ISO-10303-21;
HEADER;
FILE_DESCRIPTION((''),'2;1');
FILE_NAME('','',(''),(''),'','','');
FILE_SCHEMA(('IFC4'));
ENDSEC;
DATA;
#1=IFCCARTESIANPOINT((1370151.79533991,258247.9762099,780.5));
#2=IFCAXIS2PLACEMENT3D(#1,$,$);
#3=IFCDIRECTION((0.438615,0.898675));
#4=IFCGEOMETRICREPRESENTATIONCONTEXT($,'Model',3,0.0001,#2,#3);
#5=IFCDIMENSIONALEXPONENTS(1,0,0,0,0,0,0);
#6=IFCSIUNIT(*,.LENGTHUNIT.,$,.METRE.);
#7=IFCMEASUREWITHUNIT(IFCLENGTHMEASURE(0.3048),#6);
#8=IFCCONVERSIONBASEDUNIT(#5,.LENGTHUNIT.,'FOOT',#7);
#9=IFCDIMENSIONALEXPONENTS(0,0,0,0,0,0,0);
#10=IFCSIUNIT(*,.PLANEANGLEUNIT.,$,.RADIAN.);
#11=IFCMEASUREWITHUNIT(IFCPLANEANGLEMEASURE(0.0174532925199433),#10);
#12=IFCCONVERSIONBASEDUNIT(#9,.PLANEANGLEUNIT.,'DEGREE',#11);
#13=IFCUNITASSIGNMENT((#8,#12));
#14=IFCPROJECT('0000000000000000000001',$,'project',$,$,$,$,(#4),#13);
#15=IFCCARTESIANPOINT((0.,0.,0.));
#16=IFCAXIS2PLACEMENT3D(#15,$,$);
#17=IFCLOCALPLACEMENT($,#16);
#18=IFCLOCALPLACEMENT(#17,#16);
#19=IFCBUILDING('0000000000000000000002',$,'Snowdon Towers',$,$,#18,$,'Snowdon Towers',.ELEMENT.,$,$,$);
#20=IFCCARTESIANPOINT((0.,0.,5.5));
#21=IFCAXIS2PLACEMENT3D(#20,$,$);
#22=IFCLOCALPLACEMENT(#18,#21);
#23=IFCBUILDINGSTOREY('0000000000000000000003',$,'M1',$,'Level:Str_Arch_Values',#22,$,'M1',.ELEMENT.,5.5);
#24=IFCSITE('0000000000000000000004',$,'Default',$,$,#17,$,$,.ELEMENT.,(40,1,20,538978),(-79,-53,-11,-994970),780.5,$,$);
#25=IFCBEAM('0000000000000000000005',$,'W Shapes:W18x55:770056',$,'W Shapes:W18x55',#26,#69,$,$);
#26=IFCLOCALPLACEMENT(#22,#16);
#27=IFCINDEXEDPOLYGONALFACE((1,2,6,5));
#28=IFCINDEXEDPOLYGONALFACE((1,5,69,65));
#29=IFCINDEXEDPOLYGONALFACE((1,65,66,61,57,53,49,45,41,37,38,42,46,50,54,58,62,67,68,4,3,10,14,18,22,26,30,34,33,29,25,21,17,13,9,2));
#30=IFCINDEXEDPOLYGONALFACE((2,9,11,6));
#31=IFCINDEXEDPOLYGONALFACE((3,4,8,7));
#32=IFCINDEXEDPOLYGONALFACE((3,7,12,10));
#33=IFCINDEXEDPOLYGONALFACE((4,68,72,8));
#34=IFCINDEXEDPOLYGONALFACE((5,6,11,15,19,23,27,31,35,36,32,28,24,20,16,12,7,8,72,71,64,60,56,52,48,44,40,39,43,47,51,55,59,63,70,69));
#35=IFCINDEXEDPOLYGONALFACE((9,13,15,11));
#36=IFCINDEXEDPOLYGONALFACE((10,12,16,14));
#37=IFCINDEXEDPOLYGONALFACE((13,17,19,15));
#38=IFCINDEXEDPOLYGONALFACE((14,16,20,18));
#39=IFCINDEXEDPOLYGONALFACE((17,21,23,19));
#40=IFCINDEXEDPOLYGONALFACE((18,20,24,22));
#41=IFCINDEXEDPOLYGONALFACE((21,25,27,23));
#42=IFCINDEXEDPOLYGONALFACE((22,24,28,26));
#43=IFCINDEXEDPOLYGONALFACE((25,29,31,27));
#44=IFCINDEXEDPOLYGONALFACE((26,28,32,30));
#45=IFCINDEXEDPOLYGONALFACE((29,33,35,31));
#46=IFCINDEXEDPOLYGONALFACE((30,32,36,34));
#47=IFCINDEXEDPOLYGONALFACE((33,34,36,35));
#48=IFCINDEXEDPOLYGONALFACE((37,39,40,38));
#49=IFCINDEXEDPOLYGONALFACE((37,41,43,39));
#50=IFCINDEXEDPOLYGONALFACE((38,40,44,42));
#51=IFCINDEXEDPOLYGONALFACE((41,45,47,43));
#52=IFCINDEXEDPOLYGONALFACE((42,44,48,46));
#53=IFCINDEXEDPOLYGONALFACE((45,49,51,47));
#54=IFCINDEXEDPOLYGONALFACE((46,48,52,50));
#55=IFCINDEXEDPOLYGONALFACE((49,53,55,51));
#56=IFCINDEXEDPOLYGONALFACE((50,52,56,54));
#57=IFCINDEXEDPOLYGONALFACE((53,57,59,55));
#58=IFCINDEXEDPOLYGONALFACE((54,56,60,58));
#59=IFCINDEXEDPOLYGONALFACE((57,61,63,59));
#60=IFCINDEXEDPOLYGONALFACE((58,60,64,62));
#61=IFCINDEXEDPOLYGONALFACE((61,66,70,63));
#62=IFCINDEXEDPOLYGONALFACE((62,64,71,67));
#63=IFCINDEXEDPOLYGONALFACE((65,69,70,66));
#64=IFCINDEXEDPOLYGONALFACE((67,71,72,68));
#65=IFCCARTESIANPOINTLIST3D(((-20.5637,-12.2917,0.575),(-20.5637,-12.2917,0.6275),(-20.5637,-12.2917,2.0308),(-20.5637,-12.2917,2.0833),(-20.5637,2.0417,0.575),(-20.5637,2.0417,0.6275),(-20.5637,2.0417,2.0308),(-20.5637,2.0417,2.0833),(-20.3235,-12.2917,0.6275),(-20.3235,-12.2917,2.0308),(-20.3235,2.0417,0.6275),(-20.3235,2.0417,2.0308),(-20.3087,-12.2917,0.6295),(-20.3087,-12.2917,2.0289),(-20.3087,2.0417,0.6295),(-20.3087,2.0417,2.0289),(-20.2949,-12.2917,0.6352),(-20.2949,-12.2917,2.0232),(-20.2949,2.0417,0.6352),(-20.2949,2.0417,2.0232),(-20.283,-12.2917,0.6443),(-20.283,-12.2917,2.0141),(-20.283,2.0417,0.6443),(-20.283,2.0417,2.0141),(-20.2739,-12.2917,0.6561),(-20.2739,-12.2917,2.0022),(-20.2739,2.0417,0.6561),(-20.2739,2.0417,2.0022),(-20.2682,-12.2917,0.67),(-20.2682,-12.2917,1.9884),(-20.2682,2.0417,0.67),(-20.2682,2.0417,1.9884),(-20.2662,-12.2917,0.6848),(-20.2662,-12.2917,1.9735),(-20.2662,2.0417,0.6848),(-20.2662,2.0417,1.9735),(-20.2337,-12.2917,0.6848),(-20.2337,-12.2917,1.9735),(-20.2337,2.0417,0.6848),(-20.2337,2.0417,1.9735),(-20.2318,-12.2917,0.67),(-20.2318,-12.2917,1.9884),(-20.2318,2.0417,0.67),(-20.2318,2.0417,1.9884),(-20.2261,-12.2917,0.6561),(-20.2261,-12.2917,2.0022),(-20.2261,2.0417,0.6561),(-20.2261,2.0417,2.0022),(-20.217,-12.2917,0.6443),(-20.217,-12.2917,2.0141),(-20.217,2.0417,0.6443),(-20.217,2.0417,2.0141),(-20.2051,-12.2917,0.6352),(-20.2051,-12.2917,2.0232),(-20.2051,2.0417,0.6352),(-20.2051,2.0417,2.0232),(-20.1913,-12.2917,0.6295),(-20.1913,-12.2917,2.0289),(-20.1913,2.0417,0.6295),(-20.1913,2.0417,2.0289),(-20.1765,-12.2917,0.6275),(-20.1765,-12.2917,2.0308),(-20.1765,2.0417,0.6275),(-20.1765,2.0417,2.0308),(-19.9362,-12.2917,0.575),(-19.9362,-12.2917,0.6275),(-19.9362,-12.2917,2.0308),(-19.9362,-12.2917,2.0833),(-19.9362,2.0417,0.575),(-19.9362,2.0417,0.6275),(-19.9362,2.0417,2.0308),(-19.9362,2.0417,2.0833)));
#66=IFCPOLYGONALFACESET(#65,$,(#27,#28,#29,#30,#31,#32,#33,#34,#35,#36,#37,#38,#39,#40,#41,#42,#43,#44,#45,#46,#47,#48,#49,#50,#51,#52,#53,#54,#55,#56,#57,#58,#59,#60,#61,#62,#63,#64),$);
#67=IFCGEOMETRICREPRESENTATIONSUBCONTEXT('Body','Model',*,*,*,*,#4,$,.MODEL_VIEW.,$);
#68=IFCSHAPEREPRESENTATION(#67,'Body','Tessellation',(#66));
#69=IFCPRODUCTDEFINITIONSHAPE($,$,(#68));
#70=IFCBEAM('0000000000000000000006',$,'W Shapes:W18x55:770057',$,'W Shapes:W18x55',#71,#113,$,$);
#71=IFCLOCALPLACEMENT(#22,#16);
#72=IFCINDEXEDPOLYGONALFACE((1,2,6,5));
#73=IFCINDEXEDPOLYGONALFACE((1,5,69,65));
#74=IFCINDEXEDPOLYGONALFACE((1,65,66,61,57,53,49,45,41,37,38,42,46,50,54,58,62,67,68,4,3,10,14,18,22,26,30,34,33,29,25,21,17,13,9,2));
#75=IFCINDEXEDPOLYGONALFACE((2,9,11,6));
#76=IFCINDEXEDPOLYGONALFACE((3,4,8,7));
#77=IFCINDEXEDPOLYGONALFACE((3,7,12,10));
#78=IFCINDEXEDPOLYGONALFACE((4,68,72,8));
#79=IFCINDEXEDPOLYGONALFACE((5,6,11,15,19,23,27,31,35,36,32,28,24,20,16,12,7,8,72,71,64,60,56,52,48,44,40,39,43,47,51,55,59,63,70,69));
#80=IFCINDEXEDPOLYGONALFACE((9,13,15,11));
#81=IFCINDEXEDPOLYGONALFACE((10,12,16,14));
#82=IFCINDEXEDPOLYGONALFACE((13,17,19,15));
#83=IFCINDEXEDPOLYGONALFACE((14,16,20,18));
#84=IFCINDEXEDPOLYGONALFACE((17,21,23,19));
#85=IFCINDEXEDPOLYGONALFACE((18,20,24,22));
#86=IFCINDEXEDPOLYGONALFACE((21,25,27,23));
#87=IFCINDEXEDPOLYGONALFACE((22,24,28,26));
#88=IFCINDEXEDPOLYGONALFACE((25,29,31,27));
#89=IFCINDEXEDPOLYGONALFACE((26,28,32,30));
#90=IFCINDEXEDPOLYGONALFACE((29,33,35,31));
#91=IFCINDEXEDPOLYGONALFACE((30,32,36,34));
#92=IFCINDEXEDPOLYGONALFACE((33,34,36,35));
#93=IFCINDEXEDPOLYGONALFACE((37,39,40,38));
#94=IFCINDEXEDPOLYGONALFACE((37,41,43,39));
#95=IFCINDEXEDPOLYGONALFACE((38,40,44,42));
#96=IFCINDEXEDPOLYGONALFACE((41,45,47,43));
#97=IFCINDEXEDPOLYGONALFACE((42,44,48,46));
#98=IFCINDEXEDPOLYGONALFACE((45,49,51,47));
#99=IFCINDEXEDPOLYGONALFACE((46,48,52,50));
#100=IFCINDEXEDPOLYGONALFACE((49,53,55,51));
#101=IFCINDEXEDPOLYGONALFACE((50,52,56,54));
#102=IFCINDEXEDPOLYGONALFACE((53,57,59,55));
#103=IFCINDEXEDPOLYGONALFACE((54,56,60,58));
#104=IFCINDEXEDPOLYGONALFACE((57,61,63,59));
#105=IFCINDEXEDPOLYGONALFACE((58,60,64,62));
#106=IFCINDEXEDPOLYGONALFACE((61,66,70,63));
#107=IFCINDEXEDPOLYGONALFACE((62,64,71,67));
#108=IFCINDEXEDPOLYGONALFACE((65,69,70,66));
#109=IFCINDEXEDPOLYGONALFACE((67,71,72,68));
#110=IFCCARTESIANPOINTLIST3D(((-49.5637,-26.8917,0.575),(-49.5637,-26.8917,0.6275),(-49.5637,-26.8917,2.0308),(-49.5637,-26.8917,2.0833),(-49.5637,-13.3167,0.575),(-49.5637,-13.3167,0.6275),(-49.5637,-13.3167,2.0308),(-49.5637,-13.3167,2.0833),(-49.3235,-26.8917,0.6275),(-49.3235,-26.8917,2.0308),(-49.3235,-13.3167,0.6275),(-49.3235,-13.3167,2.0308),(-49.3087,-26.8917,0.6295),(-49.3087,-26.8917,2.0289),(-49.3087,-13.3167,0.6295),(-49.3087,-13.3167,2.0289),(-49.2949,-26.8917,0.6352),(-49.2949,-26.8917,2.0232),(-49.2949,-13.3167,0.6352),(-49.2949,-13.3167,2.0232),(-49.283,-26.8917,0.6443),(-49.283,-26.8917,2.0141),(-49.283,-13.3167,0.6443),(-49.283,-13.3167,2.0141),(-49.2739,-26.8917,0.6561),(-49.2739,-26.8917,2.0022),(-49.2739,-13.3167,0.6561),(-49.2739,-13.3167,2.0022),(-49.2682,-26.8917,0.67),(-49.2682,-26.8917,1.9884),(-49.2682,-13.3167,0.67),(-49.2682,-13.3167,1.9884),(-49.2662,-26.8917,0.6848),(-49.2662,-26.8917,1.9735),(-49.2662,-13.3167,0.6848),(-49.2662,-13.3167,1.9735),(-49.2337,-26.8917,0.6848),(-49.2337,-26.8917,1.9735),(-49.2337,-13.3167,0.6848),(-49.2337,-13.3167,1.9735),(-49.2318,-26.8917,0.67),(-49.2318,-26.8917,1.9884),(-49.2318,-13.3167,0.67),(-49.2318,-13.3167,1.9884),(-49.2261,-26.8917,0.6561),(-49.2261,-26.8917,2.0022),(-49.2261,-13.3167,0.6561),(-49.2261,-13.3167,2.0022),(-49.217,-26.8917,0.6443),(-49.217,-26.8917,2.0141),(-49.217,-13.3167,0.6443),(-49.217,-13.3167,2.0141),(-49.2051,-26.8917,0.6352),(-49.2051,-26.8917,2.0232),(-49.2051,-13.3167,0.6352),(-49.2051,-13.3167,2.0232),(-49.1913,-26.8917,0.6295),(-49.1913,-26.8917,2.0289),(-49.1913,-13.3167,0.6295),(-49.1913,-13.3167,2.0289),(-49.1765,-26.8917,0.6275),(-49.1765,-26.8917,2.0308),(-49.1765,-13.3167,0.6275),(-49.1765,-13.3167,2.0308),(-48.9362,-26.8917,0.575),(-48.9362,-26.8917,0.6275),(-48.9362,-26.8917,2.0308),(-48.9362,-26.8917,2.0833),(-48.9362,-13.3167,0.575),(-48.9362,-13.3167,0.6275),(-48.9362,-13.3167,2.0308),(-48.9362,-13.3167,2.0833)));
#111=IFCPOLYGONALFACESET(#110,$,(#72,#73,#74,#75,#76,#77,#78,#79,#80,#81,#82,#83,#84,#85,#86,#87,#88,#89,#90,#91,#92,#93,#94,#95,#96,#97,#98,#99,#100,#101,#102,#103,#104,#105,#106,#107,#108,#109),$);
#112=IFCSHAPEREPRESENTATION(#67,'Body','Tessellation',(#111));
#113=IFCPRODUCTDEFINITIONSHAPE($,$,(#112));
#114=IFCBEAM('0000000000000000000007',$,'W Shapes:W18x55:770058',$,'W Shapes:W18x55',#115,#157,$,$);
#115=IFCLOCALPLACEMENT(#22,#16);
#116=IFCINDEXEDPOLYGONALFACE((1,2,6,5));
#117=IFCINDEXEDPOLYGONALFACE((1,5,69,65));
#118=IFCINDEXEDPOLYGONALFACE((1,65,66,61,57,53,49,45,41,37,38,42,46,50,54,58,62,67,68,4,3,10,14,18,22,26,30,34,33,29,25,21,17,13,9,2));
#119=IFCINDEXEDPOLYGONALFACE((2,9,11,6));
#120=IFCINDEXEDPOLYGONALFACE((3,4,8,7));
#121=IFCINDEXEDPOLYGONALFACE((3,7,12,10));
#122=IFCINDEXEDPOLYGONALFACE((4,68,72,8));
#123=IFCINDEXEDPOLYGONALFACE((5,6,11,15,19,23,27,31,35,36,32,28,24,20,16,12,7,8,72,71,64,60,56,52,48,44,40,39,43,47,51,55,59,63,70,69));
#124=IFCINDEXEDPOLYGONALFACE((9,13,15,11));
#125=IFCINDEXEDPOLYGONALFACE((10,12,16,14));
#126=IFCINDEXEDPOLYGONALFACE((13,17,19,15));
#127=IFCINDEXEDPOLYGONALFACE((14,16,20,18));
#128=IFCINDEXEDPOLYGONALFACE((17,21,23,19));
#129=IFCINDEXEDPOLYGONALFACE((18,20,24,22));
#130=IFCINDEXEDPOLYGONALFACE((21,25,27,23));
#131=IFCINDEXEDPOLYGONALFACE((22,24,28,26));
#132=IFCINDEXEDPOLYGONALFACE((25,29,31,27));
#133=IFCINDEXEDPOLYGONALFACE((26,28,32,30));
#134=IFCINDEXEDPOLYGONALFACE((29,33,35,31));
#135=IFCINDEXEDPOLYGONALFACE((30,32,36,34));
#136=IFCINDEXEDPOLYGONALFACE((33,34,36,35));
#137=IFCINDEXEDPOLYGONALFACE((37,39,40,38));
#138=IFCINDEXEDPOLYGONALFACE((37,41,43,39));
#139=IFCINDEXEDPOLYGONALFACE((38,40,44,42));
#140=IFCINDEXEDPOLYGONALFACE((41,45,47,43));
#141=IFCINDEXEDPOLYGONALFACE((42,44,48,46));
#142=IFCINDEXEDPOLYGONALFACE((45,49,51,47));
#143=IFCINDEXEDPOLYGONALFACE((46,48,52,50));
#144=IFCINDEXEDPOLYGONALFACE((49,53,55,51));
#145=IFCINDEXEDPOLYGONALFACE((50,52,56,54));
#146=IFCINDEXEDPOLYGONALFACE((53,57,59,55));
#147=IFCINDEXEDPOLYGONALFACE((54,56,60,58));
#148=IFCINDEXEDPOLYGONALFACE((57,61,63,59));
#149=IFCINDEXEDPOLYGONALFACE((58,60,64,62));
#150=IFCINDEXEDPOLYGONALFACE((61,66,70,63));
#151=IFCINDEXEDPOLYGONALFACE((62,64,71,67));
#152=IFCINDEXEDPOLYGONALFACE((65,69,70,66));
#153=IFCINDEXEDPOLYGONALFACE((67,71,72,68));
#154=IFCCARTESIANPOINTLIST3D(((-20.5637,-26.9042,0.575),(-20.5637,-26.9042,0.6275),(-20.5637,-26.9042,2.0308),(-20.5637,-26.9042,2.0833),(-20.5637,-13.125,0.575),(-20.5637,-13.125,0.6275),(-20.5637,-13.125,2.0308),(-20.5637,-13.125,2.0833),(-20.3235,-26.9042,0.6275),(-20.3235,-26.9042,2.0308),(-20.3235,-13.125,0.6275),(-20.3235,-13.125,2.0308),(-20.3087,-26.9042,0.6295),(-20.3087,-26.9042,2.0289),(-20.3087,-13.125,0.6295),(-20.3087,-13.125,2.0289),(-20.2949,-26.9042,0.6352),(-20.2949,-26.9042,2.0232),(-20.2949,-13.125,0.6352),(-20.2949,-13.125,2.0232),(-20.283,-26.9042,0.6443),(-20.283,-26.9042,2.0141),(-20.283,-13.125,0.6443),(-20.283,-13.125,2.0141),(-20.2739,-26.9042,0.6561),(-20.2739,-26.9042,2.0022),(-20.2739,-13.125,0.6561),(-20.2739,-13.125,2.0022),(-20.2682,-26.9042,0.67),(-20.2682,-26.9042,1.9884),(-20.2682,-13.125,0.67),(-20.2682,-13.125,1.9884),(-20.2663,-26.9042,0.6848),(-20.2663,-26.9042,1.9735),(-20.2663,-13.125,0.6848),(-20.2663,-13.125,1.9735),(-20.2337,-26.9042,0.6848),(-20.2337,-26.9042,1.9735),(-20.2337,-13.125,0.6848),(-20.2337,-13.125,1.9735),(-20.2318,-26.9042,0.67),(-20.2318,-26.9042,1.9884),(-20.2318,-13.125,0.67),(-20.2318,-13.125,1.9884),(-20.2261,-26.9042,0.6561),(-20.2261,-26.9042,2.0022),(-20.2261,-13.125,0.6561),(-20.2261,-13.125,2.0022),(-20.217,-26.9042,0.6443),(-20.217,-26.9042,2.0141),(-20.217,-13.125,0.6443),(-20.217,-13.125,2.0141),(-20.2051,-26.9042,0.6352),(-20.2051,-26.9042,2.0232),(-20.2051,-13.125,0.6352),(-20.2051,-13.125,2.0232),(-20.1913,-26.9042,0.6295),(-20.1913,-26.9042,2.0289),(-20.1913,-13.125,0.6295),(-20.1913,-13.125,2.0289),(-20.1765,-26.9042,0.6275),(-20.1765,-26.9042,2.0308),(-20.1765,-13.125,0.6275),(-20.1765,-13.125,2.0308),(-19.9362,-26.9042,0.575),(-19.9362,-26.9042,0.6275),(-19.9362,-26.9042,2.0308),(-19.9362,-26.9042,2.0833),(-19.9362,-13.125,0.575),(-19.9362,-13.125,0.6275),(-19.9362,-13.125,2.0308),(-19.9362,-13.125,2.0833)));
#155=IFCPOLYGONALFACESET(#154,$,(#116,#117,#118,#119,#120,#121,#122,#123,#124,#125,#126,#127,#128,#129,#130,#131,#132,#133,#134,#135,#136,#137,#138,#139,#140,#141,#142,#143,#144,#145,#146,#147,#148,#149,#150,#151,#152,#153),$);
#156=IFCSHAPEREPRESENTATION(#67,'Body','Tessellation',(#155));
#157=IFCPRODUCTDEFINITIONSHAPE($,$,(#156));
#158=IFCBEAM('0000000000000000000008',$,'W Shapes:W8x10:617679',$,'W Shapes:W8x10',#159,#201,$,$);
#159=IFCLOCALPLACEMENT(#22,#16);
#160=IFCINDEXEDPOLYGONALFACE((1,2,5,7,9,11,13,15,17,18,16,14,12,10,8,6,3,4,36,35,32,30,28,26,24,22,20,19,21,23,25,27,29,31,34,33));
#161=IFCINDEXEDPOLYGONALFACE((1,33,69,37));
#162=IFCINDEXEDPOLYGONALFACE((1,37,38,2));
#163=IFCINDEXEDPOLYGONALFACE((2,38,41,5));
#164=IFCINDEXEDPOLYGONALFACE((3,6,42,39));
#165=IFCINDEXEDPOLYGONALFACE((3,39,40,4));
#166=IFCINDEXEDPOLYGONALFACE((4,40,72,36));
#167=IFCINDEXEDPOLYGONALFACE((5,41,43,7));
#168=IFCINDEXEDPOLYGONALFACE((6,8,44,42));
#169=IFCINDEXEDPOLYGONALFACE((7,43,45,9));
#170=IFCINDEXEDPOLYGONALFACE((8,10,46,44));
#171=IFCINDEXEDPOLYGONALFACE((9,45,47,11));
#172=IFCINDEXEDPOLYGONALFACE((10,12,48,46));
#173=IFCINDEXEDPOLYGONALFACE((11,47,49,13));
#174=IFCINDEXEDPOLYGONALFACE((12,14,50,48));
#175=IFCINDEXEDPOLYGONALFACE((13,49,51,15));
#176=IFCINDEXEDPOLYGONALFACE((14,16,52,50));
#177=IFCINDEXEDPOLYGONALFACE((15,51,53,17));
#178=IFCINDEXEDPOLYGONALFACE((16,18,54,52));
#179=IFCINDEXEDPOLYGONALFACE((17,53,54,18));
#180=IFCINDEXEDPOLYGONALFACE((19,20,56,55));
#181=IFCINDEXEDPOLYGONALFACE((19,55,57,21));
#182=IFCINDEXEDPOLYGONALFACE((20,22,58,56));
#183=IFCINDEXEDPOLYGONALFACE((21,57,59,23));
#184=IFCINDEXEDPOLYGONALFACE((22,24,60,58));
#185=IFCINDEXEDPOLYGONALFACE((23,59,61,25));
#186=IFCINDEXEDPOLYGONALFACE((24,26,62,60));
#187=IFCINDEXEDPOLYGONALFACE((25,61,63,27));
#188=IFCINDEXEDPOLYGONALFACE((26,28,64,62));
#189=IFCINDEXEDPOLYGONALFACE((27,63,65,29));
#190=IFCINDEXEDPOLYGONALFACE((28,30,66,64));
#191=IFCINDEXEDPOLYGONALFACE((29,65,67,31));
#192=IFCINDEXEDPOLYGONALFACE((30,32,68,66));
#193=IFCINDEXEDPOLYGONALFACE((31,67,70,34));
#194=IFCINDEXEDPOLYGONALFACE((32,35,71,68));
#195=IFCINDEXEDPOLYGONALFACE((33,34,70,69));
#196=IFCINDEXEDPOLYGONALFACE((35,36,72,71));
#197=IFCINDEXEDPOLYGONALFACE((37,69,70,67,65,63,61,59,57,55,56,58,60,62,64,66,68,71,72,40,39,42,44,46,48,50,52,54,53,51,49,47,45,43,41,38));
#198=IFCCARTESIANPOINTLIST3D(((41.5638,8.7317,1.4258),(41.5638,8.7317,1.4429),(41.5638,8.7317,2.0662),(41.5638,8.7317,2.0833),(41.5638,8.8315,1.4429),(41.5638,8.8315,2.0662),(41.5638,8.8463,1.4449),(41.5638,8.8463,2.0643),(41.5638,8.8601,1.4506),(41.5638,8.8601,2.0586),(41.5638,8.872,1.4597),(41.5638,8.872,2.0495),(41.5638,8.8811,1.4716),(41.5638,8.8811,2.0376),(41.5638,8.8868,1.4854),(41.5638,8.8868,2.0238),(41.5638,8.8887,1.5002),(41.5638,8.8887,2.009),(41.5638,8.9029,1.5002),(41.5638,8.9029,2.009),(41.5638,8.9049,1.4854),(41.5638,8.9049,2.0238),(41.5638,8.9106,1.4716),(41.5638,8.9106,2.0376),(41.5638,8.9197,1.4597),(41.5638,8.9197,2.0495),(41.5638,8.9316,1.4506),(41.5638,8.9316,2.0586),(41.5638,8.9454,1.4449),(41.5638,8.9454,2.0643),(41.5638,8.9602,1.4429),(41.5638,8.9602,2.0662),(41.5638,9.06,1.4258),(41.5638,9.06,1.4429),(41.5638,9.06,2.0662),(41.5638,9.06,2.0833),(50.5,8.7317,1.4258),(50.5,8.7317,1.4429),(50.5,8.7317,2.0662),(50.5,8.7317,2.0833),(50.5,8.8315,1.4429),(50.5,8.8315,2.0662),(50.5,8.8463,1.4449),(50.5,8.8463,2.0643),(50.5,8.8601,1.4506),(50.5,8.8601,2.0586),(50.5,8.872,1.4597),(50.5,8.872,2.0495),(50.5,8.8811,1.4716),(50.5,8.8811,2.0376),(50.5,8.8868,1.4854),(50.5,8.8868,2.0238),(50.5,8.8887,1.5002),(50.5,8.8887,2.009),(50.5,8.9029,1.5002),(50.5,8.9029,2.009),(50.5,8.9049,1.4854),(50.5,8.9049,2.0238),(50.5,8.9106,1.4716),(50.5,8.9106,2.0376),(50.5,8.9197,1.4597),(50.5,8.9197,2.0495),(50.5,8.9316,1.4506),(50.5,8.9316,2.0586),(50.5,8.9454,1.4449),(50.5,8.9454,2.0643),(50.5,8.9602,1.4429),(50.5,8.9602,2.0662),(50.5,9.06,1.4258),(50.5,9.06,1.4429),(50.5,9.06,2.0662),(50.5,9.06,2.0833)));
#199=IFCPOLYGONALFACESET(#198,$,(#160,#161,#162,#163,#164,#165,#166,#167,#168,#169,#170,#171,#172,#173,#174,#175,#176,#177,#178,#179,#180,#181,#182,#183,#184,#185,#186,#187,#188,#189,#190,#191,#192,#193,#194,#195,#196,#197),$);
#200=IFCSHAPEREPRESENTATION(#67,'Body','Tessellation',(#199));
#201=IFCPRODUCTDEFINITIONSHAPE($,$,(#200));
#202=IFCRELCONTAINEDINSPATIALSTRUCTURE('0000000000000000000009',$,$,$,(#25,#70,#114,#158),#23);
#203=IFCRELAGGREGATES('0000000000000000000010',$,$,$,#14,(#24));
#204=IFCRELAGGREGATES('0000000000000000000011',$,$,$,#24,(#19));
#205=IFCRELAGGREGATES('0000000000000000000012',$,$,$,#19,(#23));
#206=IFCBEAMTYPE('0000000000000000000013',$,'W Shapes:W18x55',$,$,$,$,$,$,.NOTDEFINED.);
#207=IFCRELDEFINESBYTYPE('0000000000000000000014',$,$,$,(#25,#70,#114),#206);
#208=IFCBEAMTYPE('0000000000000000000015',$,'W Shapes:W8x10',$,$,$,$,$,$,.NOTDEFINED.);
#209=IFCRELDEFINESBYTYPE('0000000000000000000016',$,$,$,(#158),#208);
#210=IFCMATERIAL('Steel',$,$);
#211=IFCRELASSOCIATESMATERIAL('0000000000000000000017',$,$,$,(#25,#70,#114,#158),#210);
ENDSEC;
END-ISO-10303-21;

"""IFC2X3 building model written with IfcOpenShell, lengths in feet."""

from ifc_helpers import new_model, entity, si_unit, converted_unit, direction, frame, frame_2d, origin, place, context, subcontext, project, spatial, i_section, extrude, material, type_object, element, save


model = new_model("IFC2X3")

# Units and contexts
model_context = context("Model", 3, precision=0.0001, world=frame((1370151.79533991, 258247.9762099, 780.5)), true_north=direction((0.438615, 0.898675)))
body_context = subcontext(model_context, "Body", "Model", "MODEL_VIEW")
ifc_project = project(units=[converted_unit("LENGTHUNIT", "FOOT", entity("IfcLengthMeasure", 0.3048), si_unit("LENGTHUNIT", "METRE"), dimensions=[1, 0, 0, 0, 0, 0, 0]), converted_unit("PLANEANGLEUNIT", "DEGREE", entity("IfcPlaneAngleMeasure", 0.0174532925199433), si_unit("PLANEANGLEUNIT", "RADIAN"), dimensions=[0, 0, 0, 0, 0, 0, 0])], contexts=[model_context])

# Site, building, storey
site_placement = place(None, origin())
site = spatial("IfcSite", under=ifc_project, at=site_placement, Name="Default", CompositionType="ELEMENT", RefLatitude=(40, 1, 20, 538978), RefLongitude=(-79, -53, -11, -994970), RefElevation=780.5)
building_placement = place(site_placement, origin())
building = spatial("IfcBuilding", under=site, at=building_placement, Name="Snowdon Towers", LongName="Snowdon Towers", CompositionType="ELEMENT")
storey_placement = place(building_placement, frame((0.0, 0.0, 5.5)))
storey = spatial("IfcBuildingStorey", under=building, at=storey_placement, Name="M1", ObjectType="Level:Str_Arch_Values", LongName="M1", CompositionType="ELEMENT", Elevation=5.5)

# Beams
ifc_material_1 = material(Name="Steel")
beam_type_1 = type_object("IfcBeamType", Name="W Shapes:W18x55", PredefinedType="NOTDEFINED")
beam_1_placement = place(storey_placement, frame((-20.25, 2.5, 2.0833), z_axis=(0.0, 0.0, 1.0), x_axis=(0.0, -1.0, 0.0)))
element("IfcBeam", 1, at=beam_1_placement, inside=storey, type_object=beam_type_1, material=ifc_material_1, Name="W Shapes:W18x55:770056", ObjectType="W Shapes:W18x55", context=body_context, shape_type="SweptSolid", body=[
    extrude(i_section(OverallWidth=0.6275, OverallDepth=1.5083, WebThickness=0.0325, FlangeThickness=0.0525, FilletRadius=0.0573, at=frame_2d((0.0, 0.0), x_axis=(0.0, 1.0))), frame((0.4583, 0.0, -0.7542), z_axis=(1.0, 0.0, 0.0), x_axis=(0.0, 0.0, -1.0)), (0.0, 0.0, 1.0), 14.3333),
])
beam_2_placement = place(storey_placement, frame((-49.25, -12.7083, 2.0833), z_axis=(0.0, 0.0, 1.0), x_axis=(0.0, -1.0, 0.0)))
element("IfcBeam", 2, at=beam_2_placement, inside=storey, type_object=beam_type_1, material=ifc_material_1, Name="W Shapes:W18x55:770057", ObjectType="W Shapes:W18x55", context=body_context, shape_type="SweptSolid", body=[
    extrude(i_section(OverallWidth=0.6275, OverallDepth=1.5083, WebThickness=0.0325, FlangeThickness=0.0525, FilletRadius=0.0573, at=frame_2d((0.0, 0.0), x_axis=(0.0, 1.0))), frame((0.6083, 0.0, -0.7542), z_axis=(1.0, 0.0, 0.0), x_axis=(0.0, 0.0, -1.0)), (0.0, 0.0, 1.0), 13.575),
])
beam_3_placement = place(storey_placement, frame((-20.25, -12.7083, 2.0833), z_axis=(0.0, 0.0, 1.0), x_axis=(0.0, -1.0, 0.0)))
element("IfcBeam", 3, at=beam_3_placement, inside=storey, type_object=beam_type_1, material=ifc_material_1, Name="W Shapes:W18x55:770058", ObjectType="W Shapes:W18x55", context=body_context, shape_type="SweptSolid", body=[
    extrude(i_section(OverallWidth=0.6275, OverallDepth=1.5083, WebThickness=0.0325, FlangeThickness=0.0525, FilletRadius=0.0573, at=frame_2d((0.0, 0.0), x_axis=(0.0, 1.0))), frame((0.4167, 0.0, -0.7542), z_axis=(1.0, 0.0, 0.0), x_axis=(0.0, 0.0, -1.0)), (0.0, 0.0, 1.0), 13.7792),
])
beam_type_2 = type_object("IfcBeamType", Name="W Shapes:W8x10", PredefinedType="NOTDEFINED")
beam_4_placement = place(storey_placement, frame((50.7917, 8.8958, 2.0833), z_axis=(0.0, 0.0, 1.0), x_axis=(-1.0, 0.0, 0.0)))
element("IfcBeam", 4, at=beam_4_placement, inside=storey, type_object=beam_type_2, material=ifc_material_1, Name="W Shapes:W8x10:617679", ObjectType="W Shapes:W8x10", context=body_context, shape_type="SweptSolid", body=[
    extrude(i_section(OverallWidth=0.3283, OverallDepth=0.6575, WebThickness=0.0142, FlangeThickness=0.0171, FilletRadius=0.0573, at=frame_2d((0.0, 0.0), x_axis=(0.0, 1.0))), frame((0.2917, 0.0, -0.3288), z_axis=(1.0, 0.0, 0.0), x_axis=(0.0, 0.0, -1.0)), (0.0, 0.0, 1.0), 8.9362),
])

save(model, "model.ifc")
